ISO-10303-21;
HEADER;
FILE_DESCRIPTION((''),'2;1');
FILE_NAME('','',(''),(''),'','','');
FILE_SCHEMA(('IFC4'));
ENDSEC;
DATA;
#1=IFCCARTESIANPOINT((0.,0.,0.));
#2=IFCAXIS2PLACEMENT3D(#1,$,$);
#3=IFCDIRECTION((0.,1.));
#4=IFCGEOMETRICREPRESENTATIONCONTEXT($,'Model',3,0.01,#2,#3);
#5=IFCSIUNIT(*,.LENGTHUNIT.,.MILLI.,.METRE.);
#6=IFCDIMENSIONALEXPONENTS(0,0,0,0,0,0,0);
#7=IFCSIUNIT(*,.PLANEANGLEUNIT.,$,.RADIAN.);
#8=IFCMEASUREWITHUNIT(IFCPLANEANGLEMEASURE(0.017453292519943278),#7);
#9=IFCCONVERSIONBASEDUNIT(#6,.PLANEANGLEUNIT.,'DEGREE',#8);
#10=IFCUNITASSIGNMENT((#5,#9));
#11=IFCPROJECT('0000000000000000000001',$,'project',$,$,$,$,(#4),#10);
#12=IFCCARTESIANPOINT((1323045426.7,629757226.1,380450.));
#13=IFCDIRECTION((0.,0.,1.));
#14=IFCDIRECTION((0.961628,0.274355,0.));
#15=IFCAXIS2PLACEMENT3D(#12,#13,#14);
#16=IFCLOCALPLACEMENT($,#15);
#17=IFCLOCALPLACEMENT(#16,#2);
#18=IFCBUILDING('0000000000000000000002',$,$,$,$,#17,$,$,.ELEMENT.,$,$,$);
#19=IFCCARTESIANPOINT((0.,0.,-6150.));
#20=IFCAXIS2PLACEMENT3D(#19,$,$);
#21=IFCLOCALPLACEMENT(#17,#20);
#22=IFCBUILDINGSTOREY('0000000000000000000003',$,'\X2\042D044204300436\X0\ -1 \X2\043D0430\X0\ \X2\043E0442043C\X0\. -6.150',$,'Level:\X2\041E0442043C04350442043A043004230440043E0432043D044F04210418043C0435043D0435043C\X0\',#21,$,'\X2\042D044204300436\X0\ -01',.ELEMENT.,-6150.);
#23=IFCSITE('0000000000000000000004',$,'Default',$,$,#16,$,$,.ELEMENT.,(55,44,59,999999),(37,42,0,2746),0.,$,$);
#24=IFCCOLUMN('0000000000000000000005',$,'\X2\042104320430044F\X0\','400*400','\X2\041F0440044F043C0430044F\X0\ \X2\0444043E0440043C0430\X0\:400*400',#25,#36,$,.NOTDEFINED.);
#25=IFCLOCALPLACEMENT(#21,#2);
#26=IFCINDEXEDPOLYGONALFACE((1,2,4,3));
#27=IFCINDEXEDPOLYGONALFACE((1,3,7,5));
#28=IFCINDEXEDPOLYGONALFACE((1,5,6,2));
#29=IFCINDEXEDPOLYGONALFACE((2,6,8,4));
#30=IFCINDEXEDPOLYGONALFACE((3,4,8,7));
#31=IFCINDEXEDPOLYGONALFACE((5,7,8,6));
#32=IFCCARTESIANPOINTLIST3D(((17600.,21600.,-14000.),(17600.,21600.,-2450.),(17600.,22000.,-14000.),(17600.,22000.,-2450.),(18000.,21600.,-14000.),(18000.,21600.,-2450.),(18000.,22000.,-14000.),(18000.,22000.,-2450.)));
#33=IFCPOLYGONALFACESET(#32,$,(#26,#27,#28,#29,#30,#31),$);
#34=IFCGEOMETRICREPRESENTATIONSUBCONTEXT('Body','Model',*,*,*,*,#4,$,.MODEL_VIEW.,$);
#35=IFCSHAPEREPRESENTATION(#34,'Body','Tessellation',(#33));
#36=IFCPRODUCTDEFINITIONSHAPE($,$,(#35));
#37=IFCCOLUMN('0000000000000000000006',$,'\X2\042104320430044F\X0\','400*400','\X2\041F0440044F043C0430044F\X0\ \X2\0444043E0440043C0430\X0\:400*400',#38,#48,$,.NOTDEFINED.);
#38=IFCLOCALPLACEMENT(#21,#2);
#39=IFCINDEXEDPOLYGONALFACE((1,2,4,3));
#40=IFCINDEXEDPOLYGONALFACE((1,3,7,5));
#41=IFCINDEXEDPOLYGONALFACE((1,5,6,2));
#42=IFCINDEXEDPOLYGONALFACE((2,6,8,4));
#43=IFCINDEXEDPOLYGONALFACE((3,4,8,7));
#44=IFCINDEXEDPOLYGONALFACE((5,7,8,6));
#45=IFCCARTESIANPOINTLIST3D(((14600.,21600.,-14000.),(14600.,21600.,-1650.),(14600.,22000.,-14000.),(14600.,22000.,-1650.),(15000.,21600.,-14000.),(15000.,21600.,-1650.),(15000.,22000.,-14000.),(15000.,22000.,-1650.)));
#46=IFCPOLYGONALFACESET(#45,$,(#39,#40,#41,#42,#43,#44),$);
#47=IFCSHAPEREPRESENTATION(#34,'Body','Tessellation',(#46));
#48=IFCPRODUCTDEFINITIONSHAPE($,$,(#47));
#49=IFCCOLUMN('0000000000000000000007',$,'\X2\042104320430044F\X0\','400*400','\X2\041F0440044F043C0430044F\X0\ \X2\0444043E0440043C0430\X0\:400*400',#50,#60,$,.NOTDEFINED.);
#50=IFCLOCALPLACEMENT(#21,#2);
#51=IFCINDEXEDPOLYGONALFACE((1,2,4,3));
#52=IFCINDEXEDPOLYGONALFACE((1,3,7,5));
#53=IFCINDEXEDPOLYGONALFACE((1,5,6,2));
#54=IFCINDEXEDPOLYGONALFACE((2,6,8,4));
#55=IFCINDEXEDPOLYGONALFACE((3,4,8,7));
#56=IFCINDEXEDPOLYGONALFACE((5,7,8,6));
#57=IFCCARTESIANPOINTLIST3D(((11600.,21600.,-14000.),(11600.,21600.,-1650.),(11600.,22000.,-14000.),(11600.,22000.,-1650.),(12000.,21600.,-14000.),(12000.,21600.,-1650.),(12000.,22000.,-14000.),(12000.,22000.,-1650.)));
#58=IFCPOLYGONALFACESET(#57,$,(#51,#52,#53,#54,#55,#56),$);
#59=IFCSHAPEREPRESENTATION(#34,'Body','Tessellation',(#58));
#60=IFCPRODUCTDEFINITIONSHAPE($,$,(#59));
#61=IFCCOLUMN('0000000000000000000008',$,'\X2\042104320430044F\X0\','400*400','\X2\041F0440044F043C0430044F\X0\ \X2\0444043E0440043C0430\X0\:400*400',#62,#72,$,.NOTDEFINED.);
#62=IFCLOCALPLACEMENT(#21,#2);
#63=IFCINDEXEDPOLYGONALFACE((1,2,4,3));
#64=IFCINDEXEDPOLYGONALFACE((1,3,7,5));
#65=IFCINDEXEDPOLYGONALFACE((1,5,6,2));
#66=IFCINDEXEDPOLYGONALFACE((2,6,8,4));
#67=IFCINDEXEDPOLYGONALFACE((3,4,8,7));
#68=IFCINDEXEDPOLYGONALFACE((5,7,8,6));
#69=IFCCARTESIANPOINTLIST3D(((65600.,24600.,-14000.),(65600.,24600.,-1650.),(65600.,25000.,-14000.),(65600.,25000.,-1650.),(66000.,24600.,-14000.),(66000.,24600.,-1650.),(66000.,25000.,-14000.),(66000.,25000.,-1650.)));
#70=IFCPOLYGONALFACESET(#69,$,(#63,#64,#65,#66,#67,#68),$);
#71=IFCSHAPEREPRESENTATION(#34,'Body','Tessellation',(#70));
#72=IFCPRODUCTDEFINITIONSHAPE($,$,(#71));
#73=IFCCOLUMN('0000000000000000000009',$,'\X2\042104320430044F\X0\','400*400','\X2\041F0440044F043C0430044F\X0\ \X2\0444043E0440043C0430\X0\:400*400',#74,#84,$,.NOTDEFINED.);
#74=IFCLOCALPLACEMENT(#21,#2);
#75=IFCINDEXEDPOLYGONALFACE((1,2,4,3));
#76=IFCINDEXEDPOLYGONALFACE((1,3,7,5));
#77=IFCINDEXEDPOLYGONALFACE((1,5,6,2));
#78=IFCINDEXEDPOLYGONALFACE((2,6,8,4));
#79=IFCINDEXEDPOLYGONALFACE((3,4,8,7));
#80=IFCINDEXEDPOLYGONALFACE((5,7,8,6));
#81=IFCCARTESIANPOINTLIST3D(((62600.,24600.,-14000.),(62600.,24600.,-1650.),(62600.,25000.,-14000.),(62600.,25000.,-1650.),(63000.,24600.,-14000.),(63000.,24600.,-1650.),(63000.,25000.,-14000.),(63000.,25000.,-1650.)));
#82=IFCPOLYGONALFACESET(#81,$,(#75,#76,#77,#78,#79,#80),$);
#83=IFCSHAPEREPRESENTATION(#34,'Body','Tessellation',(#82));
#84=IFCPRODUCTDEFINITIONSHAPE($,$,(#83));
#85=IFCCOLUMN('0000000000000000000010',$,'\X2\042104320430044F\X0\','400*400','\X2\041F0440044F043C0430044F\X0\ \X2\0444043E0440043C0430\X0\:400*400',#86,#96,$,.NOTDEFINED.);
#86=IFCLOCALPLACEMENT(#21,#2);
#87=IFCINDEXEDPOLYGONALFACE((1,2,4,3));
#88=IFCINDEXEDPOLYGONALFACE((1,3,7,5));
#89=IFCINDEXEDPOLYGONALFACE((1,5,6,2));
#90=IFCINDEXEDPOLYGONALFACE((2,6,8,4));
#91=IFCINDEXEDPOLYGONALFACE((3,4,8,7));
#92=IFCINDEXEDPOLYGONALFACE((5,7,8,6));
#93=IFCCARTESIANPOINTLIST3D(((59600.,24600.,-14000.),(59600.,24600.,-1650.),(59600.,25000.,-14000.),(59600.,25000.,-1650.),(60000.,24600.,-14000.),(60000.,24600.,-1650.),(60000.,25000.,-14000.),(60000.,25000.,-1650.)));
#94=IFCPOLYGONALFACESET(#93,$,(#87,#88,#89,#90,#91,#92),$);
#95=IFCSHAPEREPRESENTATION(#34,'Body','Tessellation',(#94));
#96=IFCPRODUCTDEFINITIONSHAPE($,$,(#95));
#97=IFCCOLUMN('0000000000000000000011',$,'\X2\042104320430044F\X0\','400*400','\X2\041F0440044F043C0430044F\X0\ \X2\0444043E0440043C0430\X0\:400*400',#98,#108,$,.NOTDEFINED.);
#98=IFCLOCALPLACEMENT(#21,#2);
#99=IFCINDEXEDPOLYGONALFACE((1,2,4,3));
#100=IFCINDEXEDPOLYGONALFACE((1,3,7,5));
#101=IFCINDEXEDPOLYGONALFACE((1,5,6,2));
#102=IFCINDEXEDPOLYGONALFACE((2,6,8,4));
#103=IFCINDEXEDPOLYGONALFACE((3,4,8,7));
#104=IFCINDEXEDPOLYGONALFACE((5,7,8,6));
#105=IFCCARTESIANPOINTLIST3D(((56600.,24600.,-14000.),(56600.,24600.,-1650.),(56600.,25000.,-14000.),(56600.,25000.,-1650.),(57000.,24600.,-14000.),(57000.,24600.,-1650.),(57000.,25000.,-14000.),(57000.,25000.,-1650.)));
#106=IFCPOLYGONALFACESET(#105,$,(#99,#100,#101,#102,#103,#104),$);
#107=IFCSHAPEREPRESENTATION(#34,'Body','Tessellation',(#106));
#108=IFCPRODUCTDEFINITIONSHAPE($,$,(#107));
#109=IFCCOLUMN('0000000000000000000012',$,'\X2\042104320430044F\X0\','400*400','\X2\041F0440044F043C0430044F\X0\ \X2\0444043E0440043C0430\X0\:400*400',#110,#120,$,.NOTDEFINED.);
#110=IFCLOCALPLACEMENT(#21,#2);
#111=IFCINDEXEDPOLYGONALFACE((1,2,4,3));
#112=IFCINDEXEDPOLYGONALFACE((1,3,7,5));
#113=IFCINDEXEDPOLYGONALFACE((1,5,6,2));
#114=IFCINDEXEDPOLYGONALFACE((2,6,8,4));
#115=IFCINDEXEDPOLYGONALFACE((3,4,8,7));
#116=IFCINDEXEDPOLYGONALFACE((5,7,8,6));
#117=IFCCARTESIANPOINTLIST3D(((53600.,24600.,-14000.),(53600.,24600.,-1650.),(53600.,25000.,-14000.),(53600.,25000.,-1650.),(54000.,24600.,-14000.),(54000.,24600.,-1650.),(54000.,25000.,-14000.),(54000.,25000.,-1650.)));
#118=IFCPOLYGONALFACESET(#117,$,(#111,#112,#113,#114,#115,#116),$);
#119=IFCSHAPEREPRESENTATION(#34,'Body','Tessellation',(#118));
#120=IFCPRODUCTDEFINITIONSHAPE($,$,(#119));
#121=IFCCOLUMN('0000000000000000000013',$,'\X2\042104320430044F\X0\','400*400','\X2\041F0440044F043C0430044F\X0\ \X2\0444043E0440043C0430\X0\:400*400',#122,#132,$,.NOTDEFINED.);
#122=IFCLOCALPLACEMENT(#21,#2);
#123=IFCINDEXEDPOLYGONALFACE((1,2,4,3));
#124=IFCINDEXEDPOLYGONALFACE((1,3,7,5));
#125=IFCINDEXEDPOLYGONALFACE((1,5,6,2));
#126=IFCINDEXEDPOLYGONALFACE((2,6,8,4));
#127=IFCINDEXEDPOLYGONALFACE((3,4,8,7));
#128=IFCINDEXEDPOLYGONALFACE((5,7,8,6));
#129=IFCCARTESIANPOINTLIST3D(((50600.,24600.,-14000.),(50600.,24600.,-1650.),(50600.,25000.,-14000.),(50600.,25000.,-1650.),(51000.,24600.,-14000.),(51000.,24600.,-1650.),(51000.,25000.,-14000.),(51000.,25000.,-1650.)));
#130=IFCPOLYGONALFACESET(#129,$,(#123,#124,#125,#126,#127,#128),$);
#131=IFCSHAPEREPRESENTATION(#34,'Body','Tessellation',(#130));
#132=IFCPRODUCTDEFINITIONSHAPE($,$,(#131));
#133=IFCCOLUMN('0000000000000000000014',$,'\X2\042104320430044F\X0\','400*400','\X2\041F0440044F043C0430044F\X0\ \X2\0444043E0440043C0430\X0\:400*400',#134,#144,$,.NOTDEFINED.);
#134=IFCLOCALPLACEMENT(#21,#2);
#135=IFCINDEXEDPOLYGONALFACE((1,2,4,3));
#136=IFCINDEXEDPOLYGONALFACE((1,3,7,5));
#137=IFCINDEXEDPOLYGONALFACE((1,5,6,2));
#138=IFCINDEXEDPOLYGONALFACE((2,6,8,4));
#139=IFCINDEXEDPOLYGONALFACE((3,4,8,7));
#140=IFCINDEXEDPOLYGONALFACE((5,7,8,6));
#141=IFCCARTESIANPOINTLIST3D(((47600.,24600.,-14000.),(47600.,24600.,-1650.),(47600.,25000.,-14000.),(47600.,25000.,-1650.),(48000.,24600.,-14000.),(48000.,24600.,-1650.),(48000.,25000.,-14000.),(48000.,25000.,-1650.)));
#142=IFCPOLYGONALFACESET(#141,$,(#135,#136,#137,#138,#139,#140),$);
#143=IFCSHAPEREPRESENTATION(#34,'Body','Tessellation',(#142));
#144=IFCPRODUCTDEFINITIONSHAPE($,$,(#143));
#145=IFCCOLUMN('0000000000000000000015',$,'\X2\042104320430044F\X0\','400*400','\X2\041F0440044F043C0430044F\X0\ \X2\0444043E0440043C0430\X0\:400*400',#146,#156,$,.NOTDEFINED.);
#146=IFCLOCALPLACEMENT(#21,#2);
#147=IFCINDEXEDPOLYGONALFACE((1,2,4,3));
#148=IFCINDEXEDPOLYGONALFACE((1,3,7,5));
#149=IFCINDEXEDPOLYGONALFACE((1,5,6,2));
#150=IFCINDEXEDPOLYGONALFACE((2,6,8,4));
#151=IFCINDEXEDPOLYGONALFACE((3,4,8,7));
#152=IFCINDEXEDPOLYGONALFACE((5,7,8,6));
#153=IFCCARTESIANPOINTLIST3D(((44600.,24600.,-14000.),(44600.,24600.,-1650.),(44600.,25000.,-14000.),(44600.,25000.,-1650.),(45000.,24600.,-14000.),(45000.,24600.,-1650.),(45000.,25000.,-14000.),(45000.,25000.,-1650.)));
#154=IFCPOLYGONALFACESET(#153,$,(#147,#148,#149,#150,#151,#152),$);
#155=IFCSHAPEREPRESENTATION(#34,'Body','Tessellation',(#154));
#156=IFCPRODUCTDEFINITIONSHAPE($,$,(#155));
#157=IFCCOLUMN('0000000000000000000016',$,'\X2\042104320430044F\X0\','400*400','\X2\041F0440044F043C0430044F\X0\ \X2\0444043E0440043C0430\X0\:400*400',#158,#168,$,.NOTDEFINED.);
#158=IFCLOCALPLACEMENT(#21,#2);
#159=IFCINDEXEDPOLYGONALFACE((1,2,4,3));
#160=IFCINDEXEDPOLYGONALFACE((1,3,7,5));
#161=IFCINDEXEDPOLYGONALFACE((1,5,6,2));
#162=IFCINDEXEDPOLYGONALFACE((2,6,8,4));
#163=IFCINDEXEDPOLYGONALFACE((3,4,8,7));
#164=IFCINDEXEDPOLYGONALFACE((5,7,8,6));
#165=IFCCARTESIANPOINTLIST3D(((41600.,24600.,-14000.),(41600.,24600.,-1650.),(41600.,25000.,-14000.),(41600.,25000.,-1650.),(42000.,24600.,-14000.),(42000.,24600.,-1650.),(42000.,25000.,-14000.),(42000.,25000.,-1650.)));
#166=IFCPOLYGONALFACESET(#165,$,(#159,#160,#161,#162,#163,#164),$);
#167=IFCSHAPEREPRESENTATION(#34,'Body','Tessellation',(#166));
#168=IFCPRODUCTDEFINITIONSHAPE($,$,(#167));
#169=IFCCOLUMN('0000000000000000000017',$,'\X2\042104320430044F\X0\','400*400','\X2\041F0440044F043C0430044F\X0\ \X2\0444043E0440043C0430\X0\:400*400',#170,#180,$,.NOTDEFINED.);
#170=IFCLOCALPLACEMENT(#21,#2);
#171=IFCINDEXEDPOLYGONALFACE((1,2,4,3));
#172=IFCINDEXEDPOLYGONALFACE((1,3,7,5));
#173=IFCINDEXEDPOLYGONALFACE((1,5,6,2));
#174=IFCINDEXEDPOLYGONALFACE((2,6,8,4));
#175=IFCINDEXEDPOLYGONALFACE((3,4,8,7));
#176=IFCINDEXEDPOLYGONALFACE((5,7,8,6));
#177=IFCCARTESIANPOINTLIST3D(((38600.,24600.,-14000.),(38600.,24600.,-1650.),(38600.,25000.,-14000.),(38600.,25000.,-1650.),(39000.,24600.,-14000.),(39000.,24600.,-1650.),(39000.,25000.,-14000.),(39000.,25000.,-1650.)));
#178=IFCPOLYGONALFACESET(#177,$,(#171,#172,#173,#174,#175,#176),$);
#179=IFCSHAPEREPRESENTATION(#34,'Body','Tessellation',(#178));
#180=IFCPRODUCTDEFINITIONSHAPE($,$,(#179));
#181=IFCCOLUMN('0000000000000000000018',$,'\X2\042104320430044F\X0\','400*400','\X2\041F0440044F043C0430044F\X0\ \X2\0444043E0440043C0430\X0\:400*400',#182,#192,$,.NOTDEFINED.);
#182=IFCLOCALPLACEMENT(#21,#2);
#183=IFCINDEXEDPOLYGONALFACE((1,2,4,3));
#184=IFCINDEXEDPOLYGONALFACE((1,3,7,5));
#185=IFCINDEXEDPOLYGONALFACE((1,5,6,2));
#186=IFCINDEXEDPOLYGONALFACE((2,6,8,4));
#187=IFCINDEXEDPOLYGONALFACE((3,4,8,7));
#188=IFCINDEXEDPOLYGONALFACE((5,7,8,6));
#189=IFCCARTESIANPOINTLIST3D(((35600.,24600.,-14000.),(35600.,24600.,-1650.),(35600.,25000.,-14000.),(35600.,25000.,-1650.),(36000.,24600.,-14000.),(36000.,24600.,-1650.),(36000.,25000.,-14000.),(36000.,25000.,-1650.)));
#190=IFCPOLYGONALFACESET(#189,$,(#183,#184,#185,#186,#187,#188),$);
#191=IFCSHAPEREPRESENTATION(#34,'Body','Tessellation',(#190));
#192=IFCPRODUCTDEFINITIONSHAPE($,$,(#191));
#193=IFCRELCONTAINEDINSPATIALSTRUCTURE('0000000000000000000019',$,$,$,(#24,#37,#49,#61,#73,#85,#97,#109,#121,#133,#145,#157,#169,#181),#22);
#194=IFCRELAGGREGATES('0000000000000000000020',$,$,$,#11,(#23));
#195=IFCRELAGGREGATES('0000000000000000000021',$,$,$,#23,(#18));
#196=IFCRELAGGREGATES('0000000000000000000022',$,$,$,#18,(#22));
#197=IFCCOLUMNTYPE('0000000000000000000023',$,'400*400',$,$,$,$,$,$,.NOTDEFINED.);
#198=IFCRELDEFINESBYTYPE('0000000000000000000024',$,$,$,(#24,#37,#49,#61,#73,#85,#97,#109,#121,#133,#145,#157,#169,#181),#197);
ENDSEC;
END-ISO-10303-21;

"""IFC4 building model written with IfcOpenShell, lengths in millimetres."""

from ifc_helpers import new_model, entity, si_unit, converted_unit, direction, frame, origin, place, context, subcontext, project, spatial, indexed_curve, outline, extrude, type_object, element, save


model = new_model("IFC4")

# Units and contexts
model_context = context("Model", 3, precision=0.01, world=origin(), true_north=direction((0.0, 1.0)))
body_context = subcontext(model_context, "Body", "Model", "MODEL_VIEW")
ifc_project = project(units=[si_unit("LENGTHUNIT", "METRE", prefix="MILLI"), converted_unit("PLANEANGLEUNIT", "DEGREE", entity("IfcPlaneAngleMeasure", 0.017453292519943278), si_unit("PLANEANGLEUNIT", "RADIAN"), dimensions=[0, 0, 0, 0, 0, 0, 0])], contexts=[model_context])

# Site, building, storey
site_placement = place(None, frame((1323045426.7, 629757226.1, 380450.0), z_axis=(0.0, 0.0, 1.0), x_axis=(0.961628, 0.274355, 0.0)))
site = spatial("IfcSite", under=ifc_project, at=site_placement, Name="Default", CompositionType="ELEMENT", RefLatitude=(55, 44, 59, 999999), RefLongitude=(37, 42, 0, 2746), RefElevation=0.0)
building_placement = place(site_placement, origin())
building = spatial("IfcBuilding", under=site, at=building_placement, CompositionType="ELEMENT")
storey_placement = place(building_placement, frame((0.0, 0.0, -6150.0)))
storey = spatial("IfcBuildingStorey", under=building, at=storey_placement, Name="Этаж -1 на отм. -6.150", ObjectType="Level:ОтметкаУровняСИменем", LongName="Этаж -01", CompositionType="ELEMENT", Elevation=-6150.0)

# Columns
column_type = type_object("IfcColumnType", Name="400*400", PredefinedType="NOTDEFINED")
column_1_placement = place(storey_placement, origin())
element("IfcColumn", 1, at=column_1_placement, inside=storey, type_object=column_type, Name="Свая", Description="400*400", ObjectType="Прямая форма:400*400", PredefinedType="NOTDEFINED", context=body_context, shape_type="SweptSolid", body=[
    extrude(outline(indexed_curve([(-200.0, -200.0), (200.0, -200.0), (200.0, 200.0), (-200.0, 200.0), (-200.0, -200.0)], self_intersect=False)), frame((17800.0, 21800.0, -14000.0), z_axis=(0.0, 0.0, 1.0), x_axis=(0.0, 1.0, 0.0)), (0.0, 0.0, 1.0), 11550.0),
])
column_2_placement = place(storey_placement, origin())
element("IfcColumn", 2, at=column_2_placement, inside=storey, type_object=column_type, Name="Свая", Description="400*400", ObjectType="Прямая форма:400*400", PredefinedType="NOTDEFINED", context=body_context, shape_type="SweptSolid", body=[
    extrude(outline(indexed_curve([(-200.0, -200.0), (200.0, -200.0), (200.0, 200.0), (-200.0, 200.0), (-200.0, -200.0)], self_intersect=False)), frame((14800.0, 21800.0, -14000.0), z_axis=(0.0, 0.0, 1.0), x_axis=(0.0, 1.0, 0.0)), (0.0, 0.0, 1.0), 12350.0),
])
column_3_placement = place(storey_placement, origin())
element("IfcColumn", 3, at=column_3_placement, inside=storey, type_object=column_type, Name="Свая", Description="400*400", ObjectType="Прямая форма:400*400", PredefinedType="NOTDEFINED", context=body_context, shape_type="SweptSolid", body=[
    extrude(outline(indexed_curve([(-200.0, -200.0), (200.0, -200.0), (200.0, 200.0), (-200.0, 200.0), (-200.0, -200.0)], self_intersect=False)), frame((11800.0, 21800.0, -14000.0), z_axis=(0.0, 0.0, 1.0), x_axis=(0.0, 1.0, 0.0)), (0.0, 0.0, 1.0), 12350.0),
])
column_4_placement = place(storey_placement, origin())
element("IfcColumn", 4, at=column_4_placement, inside=storey, type_object=column_type, Name="Свая", Description="400*400", ObjectType="Прямая форма:400*400", PredefinedType="NOTDEFINED", context=body_context, shape_type="SweptSolid", body=[
    extrude(outline(indexed_curve([(-200.0, -200.0), (200.0, -200.0), (200.0, 200.0), (-200.0, 200.0), (-200.0, -200.0)], self_intersect=False)), frame((65800.0, 24800.0, -14000.0), z_axis=(0.0, 0.0, 1.0), x_axis=(0.0, 1.0, 0.0)), (0.0, 0.0, 1.0), 12350.0),
])
column_5_placement = place(storey_placement, origin())
element("IfcColumn", 5, at=column_5_placement, inside=storey, type_object=column_type, Name="Свая", Description="400*400", ObjectType="Прямая форма:400*400", PredefinedType="NOTDEFINED", context=body_context, shape_type="SweptSolid", body=[
    extrude(outline(indexed_curve([(-200.0, -200.0), (200.0, -200.0), (200.0, 200.0), (-200.0, 200.0), (-200.0, -200.0)], self_intersect=False)), frame((62800.0, 24800.0, -14000.0), z_axis=(0.0, 0.0, 1.0), x_axis=(0.0, 1.0, 0.0)), (0.0, 0.0, 1.0), 12350.0),
])
column_6_placement = place(storey_placement, origin())
element("IfcColumn", 6, at=column_6_placement, inside=storey, type_object=column_type, Name="Свая", Description="400*400", ObjectType="Прямая форма:400*400", PredefinedType="NOTDEFINED", context=body_context, shape_type="SweptSolid", body=[
    extrude(outline(indexed_curve([(-200.0, -200.0), (200.0, -200.0), (200.0, 200.0), (-200.0, 200.0), (-200.0, -200.0)], self_intersect=False)), frame((59800.0, 24800.0, -14000.0), z_axis=(0.0, 0.0, 1.0), x_axis=(0.0, 1.0, 0.0)), (0.0, 0.0, 1.0), 12350.0),
])
column_7_placement = place(storey_placement, origin())
element("IfcColumn", 7, at=column_7_placement, inside=storey, type_object=column_type, Name="Свая", Description="400*400", ObjectType="Прямая форма:400*400", PredefinedType="NOTDEFINED", context=body_context, shape_type="SweptSolid", body=[
    extrude(outline(indexed_curve([(-200.0, -200.0), (200.0, -200.0), (200.0, 200.0), (-200.0, 200.0), (-200.0, -200.0)], self_intersect=False)), frame((56800.0, 24800.0, -14000.0), z_axis=(0.0, 0.0, 1.0), x_axis=(0.0, 1.0, 0.0)), (0.0, 0.0, 1.0), 12350.0),
])
column_8_placement = place(storey_placement, origin())
element("IfcColumn", 8, at=column_8_placement, inside=storey, type_object=column_type, Name="Свая", Description="400*400", ObjectType="Прямая форма:400*400", PredefinedType="NOTDEFINED", context=body_context, shape_type="SweptSolid", body=[
    extrude(outline(indexed_curve([(-200.0, -200.0), (200.0, -200.0), (200.0, 200.0), (-200.0, 200.0), (-200.0, -200.0)], self_intersect=False)), frame((53800.0, 24800.0, -14000.0), z_axis=(0.0, 0.0, 1.0), x_axis=(0.0, 1.0, 0.0)), (0.0, 0.0, 1.0), 12350.0),
])
column_9_placement = place(storey_placement, origin())
element("IfcColumn", 9, at=column_9_placement, inside=storey, type_object=column_type, Name="Свая", Description="400*400", ObjectType="Прямая форма:400*400", PredefinedType="NOTDEFINED", context=body_context, shape_type="SweptSolid", body=[
    extrude(outline(indexed_curve([(-200.0, -200.0), (200.0, -200.0), (200.0, 200.0), (-200.0, 200.0), (-200.0, -200.0)], self_intersect=False)), frame((50800.0, 24800.0, -14000.0), z_axis=(0.0, 0.0, 1.0), x_axis=(0.0, 1.0, 0.0)), (0.0, 0.0, 1.0), 12350.0),
])
column_10_placement = place(storey_placement, origin())
element("IfcColumn", 10, at=column_10_placement, inside=storey, type_object=column_type, Name="Свая", Description="400*400", ObjectType="Прямая форма:400*400", PredefinedType="NOTDEFINED", context=body_context, shape_type="SweptSolid", body=[
    extrude(outline(indexed_curve([(-200.0, -200.0), (200.0, -200.0), (200.0, 200.0), (-200.0, 200.0), (-200.0, -200.0)], self_intersect=False)), frame((47800.0, 24800.0, -14000.0), z_axis=(0.0, 0.0, 1.0), x_axis=(0.0, 1.0, 0.0)), (0.0, 0.0, 1.0), 12350.0),
])
column_11_placement = place(storey_placement, origin())
element("IfcColumn", 11, at=column_11_placement, inside=storey, type_object=column_type, Name="Свая", Description="400*400", ObjectType="Прямая форма:400*400", PredefinedType="NOTDEFINED", context=body_context, shape_type="SweptSolid", body=[
    extrude(outline(indexed_curve([(-200.0, -200.0), (200.0, -200.0), (200.0, 200.0), (-200.0, 200.0), (-200.0, -200.0)], self_intersect=False)), frame((44800.0, 24800.0, -14000.0), z_axis=(0.0, 0.0, 1.0), x_axis=(0.0, 1.0, 0.0)), (0.0, 0.0, 1.0), 12350.0),
])
column_12_placement = place(storey_placement, origin())
element("IfcColumn", 12, at=column_12_placement, inside=storey, type_object=column_type, Name="Свая", Description="400*400", ObjectType="Прямая форма:400*400", PredefinedType="NOTDEFINED", context=body_context, shape_type="SweptSolid", body=[
    extrude(outline(indexed_curve([(-200.0, -200.0), (200.0, -200.0), (200.0, 200.0), (-200.0, 200.0), (-200.0, -200.0)], self_intersect=False)), frame((41800.0, 24800.0, -14000.0), z_axis=(0.0, 0.0, 1.0), x_axis=(0.0, 1.0, 0.0)), (0.0, 0.0, 1.0), 12350.0),
])
column_13_placement = place(storey_placement, origin())
element("IfcColumn", 13, at=column_13_placement, inside=storey, type_object=column_type, Name="Свая", Description="400*400", ObjectType="Прямая форма:400*400", PredefinedType="NOTDEFINED", context=body_context, shape_type="SweptSolid", body=[
    extrude(outline(indexed_curve([(-200.0, -200.0), (200.0, -200.0), (200.0, 200.0), (-200.0, 200.0), (-200.0, -200.0)], self_intersect=False)), frame((38800.0, 24800.0, -14000.0), z_axis=(0.0, 0.0, 1.0), x_axis=(0.0, 1.0, 0.0)), (0.0, 0.0, 1.0), 12350.0),
])
column_14_placement = place(storey_placement, origin())
element("IfcColumn", 14, at=column_14_placement, inside=storey, type_object=column_type, Name="Свая", Description="400*400", ObjectType="Прямая форма:400*400", PredefinedType="NOTDEFINED", context=body_context, shape_type="SweptSolid", body=[
    extrude(outline(indexed_curve([(-200.0, -200.0), (200.0, -200.0), (200.0, 200.0), (-200.0, 200.0), (-200.0, -200.0)], self_intersect=False)), frame((35800.0, 24800.0, -14000.0), z_axis=(0.0, 0.0, 1.0), x_axis=(0.0, 1.0, 0.0)), (0.0, 0.0, 1.0), 12350.0),
])

save(model, "model.ifc")
